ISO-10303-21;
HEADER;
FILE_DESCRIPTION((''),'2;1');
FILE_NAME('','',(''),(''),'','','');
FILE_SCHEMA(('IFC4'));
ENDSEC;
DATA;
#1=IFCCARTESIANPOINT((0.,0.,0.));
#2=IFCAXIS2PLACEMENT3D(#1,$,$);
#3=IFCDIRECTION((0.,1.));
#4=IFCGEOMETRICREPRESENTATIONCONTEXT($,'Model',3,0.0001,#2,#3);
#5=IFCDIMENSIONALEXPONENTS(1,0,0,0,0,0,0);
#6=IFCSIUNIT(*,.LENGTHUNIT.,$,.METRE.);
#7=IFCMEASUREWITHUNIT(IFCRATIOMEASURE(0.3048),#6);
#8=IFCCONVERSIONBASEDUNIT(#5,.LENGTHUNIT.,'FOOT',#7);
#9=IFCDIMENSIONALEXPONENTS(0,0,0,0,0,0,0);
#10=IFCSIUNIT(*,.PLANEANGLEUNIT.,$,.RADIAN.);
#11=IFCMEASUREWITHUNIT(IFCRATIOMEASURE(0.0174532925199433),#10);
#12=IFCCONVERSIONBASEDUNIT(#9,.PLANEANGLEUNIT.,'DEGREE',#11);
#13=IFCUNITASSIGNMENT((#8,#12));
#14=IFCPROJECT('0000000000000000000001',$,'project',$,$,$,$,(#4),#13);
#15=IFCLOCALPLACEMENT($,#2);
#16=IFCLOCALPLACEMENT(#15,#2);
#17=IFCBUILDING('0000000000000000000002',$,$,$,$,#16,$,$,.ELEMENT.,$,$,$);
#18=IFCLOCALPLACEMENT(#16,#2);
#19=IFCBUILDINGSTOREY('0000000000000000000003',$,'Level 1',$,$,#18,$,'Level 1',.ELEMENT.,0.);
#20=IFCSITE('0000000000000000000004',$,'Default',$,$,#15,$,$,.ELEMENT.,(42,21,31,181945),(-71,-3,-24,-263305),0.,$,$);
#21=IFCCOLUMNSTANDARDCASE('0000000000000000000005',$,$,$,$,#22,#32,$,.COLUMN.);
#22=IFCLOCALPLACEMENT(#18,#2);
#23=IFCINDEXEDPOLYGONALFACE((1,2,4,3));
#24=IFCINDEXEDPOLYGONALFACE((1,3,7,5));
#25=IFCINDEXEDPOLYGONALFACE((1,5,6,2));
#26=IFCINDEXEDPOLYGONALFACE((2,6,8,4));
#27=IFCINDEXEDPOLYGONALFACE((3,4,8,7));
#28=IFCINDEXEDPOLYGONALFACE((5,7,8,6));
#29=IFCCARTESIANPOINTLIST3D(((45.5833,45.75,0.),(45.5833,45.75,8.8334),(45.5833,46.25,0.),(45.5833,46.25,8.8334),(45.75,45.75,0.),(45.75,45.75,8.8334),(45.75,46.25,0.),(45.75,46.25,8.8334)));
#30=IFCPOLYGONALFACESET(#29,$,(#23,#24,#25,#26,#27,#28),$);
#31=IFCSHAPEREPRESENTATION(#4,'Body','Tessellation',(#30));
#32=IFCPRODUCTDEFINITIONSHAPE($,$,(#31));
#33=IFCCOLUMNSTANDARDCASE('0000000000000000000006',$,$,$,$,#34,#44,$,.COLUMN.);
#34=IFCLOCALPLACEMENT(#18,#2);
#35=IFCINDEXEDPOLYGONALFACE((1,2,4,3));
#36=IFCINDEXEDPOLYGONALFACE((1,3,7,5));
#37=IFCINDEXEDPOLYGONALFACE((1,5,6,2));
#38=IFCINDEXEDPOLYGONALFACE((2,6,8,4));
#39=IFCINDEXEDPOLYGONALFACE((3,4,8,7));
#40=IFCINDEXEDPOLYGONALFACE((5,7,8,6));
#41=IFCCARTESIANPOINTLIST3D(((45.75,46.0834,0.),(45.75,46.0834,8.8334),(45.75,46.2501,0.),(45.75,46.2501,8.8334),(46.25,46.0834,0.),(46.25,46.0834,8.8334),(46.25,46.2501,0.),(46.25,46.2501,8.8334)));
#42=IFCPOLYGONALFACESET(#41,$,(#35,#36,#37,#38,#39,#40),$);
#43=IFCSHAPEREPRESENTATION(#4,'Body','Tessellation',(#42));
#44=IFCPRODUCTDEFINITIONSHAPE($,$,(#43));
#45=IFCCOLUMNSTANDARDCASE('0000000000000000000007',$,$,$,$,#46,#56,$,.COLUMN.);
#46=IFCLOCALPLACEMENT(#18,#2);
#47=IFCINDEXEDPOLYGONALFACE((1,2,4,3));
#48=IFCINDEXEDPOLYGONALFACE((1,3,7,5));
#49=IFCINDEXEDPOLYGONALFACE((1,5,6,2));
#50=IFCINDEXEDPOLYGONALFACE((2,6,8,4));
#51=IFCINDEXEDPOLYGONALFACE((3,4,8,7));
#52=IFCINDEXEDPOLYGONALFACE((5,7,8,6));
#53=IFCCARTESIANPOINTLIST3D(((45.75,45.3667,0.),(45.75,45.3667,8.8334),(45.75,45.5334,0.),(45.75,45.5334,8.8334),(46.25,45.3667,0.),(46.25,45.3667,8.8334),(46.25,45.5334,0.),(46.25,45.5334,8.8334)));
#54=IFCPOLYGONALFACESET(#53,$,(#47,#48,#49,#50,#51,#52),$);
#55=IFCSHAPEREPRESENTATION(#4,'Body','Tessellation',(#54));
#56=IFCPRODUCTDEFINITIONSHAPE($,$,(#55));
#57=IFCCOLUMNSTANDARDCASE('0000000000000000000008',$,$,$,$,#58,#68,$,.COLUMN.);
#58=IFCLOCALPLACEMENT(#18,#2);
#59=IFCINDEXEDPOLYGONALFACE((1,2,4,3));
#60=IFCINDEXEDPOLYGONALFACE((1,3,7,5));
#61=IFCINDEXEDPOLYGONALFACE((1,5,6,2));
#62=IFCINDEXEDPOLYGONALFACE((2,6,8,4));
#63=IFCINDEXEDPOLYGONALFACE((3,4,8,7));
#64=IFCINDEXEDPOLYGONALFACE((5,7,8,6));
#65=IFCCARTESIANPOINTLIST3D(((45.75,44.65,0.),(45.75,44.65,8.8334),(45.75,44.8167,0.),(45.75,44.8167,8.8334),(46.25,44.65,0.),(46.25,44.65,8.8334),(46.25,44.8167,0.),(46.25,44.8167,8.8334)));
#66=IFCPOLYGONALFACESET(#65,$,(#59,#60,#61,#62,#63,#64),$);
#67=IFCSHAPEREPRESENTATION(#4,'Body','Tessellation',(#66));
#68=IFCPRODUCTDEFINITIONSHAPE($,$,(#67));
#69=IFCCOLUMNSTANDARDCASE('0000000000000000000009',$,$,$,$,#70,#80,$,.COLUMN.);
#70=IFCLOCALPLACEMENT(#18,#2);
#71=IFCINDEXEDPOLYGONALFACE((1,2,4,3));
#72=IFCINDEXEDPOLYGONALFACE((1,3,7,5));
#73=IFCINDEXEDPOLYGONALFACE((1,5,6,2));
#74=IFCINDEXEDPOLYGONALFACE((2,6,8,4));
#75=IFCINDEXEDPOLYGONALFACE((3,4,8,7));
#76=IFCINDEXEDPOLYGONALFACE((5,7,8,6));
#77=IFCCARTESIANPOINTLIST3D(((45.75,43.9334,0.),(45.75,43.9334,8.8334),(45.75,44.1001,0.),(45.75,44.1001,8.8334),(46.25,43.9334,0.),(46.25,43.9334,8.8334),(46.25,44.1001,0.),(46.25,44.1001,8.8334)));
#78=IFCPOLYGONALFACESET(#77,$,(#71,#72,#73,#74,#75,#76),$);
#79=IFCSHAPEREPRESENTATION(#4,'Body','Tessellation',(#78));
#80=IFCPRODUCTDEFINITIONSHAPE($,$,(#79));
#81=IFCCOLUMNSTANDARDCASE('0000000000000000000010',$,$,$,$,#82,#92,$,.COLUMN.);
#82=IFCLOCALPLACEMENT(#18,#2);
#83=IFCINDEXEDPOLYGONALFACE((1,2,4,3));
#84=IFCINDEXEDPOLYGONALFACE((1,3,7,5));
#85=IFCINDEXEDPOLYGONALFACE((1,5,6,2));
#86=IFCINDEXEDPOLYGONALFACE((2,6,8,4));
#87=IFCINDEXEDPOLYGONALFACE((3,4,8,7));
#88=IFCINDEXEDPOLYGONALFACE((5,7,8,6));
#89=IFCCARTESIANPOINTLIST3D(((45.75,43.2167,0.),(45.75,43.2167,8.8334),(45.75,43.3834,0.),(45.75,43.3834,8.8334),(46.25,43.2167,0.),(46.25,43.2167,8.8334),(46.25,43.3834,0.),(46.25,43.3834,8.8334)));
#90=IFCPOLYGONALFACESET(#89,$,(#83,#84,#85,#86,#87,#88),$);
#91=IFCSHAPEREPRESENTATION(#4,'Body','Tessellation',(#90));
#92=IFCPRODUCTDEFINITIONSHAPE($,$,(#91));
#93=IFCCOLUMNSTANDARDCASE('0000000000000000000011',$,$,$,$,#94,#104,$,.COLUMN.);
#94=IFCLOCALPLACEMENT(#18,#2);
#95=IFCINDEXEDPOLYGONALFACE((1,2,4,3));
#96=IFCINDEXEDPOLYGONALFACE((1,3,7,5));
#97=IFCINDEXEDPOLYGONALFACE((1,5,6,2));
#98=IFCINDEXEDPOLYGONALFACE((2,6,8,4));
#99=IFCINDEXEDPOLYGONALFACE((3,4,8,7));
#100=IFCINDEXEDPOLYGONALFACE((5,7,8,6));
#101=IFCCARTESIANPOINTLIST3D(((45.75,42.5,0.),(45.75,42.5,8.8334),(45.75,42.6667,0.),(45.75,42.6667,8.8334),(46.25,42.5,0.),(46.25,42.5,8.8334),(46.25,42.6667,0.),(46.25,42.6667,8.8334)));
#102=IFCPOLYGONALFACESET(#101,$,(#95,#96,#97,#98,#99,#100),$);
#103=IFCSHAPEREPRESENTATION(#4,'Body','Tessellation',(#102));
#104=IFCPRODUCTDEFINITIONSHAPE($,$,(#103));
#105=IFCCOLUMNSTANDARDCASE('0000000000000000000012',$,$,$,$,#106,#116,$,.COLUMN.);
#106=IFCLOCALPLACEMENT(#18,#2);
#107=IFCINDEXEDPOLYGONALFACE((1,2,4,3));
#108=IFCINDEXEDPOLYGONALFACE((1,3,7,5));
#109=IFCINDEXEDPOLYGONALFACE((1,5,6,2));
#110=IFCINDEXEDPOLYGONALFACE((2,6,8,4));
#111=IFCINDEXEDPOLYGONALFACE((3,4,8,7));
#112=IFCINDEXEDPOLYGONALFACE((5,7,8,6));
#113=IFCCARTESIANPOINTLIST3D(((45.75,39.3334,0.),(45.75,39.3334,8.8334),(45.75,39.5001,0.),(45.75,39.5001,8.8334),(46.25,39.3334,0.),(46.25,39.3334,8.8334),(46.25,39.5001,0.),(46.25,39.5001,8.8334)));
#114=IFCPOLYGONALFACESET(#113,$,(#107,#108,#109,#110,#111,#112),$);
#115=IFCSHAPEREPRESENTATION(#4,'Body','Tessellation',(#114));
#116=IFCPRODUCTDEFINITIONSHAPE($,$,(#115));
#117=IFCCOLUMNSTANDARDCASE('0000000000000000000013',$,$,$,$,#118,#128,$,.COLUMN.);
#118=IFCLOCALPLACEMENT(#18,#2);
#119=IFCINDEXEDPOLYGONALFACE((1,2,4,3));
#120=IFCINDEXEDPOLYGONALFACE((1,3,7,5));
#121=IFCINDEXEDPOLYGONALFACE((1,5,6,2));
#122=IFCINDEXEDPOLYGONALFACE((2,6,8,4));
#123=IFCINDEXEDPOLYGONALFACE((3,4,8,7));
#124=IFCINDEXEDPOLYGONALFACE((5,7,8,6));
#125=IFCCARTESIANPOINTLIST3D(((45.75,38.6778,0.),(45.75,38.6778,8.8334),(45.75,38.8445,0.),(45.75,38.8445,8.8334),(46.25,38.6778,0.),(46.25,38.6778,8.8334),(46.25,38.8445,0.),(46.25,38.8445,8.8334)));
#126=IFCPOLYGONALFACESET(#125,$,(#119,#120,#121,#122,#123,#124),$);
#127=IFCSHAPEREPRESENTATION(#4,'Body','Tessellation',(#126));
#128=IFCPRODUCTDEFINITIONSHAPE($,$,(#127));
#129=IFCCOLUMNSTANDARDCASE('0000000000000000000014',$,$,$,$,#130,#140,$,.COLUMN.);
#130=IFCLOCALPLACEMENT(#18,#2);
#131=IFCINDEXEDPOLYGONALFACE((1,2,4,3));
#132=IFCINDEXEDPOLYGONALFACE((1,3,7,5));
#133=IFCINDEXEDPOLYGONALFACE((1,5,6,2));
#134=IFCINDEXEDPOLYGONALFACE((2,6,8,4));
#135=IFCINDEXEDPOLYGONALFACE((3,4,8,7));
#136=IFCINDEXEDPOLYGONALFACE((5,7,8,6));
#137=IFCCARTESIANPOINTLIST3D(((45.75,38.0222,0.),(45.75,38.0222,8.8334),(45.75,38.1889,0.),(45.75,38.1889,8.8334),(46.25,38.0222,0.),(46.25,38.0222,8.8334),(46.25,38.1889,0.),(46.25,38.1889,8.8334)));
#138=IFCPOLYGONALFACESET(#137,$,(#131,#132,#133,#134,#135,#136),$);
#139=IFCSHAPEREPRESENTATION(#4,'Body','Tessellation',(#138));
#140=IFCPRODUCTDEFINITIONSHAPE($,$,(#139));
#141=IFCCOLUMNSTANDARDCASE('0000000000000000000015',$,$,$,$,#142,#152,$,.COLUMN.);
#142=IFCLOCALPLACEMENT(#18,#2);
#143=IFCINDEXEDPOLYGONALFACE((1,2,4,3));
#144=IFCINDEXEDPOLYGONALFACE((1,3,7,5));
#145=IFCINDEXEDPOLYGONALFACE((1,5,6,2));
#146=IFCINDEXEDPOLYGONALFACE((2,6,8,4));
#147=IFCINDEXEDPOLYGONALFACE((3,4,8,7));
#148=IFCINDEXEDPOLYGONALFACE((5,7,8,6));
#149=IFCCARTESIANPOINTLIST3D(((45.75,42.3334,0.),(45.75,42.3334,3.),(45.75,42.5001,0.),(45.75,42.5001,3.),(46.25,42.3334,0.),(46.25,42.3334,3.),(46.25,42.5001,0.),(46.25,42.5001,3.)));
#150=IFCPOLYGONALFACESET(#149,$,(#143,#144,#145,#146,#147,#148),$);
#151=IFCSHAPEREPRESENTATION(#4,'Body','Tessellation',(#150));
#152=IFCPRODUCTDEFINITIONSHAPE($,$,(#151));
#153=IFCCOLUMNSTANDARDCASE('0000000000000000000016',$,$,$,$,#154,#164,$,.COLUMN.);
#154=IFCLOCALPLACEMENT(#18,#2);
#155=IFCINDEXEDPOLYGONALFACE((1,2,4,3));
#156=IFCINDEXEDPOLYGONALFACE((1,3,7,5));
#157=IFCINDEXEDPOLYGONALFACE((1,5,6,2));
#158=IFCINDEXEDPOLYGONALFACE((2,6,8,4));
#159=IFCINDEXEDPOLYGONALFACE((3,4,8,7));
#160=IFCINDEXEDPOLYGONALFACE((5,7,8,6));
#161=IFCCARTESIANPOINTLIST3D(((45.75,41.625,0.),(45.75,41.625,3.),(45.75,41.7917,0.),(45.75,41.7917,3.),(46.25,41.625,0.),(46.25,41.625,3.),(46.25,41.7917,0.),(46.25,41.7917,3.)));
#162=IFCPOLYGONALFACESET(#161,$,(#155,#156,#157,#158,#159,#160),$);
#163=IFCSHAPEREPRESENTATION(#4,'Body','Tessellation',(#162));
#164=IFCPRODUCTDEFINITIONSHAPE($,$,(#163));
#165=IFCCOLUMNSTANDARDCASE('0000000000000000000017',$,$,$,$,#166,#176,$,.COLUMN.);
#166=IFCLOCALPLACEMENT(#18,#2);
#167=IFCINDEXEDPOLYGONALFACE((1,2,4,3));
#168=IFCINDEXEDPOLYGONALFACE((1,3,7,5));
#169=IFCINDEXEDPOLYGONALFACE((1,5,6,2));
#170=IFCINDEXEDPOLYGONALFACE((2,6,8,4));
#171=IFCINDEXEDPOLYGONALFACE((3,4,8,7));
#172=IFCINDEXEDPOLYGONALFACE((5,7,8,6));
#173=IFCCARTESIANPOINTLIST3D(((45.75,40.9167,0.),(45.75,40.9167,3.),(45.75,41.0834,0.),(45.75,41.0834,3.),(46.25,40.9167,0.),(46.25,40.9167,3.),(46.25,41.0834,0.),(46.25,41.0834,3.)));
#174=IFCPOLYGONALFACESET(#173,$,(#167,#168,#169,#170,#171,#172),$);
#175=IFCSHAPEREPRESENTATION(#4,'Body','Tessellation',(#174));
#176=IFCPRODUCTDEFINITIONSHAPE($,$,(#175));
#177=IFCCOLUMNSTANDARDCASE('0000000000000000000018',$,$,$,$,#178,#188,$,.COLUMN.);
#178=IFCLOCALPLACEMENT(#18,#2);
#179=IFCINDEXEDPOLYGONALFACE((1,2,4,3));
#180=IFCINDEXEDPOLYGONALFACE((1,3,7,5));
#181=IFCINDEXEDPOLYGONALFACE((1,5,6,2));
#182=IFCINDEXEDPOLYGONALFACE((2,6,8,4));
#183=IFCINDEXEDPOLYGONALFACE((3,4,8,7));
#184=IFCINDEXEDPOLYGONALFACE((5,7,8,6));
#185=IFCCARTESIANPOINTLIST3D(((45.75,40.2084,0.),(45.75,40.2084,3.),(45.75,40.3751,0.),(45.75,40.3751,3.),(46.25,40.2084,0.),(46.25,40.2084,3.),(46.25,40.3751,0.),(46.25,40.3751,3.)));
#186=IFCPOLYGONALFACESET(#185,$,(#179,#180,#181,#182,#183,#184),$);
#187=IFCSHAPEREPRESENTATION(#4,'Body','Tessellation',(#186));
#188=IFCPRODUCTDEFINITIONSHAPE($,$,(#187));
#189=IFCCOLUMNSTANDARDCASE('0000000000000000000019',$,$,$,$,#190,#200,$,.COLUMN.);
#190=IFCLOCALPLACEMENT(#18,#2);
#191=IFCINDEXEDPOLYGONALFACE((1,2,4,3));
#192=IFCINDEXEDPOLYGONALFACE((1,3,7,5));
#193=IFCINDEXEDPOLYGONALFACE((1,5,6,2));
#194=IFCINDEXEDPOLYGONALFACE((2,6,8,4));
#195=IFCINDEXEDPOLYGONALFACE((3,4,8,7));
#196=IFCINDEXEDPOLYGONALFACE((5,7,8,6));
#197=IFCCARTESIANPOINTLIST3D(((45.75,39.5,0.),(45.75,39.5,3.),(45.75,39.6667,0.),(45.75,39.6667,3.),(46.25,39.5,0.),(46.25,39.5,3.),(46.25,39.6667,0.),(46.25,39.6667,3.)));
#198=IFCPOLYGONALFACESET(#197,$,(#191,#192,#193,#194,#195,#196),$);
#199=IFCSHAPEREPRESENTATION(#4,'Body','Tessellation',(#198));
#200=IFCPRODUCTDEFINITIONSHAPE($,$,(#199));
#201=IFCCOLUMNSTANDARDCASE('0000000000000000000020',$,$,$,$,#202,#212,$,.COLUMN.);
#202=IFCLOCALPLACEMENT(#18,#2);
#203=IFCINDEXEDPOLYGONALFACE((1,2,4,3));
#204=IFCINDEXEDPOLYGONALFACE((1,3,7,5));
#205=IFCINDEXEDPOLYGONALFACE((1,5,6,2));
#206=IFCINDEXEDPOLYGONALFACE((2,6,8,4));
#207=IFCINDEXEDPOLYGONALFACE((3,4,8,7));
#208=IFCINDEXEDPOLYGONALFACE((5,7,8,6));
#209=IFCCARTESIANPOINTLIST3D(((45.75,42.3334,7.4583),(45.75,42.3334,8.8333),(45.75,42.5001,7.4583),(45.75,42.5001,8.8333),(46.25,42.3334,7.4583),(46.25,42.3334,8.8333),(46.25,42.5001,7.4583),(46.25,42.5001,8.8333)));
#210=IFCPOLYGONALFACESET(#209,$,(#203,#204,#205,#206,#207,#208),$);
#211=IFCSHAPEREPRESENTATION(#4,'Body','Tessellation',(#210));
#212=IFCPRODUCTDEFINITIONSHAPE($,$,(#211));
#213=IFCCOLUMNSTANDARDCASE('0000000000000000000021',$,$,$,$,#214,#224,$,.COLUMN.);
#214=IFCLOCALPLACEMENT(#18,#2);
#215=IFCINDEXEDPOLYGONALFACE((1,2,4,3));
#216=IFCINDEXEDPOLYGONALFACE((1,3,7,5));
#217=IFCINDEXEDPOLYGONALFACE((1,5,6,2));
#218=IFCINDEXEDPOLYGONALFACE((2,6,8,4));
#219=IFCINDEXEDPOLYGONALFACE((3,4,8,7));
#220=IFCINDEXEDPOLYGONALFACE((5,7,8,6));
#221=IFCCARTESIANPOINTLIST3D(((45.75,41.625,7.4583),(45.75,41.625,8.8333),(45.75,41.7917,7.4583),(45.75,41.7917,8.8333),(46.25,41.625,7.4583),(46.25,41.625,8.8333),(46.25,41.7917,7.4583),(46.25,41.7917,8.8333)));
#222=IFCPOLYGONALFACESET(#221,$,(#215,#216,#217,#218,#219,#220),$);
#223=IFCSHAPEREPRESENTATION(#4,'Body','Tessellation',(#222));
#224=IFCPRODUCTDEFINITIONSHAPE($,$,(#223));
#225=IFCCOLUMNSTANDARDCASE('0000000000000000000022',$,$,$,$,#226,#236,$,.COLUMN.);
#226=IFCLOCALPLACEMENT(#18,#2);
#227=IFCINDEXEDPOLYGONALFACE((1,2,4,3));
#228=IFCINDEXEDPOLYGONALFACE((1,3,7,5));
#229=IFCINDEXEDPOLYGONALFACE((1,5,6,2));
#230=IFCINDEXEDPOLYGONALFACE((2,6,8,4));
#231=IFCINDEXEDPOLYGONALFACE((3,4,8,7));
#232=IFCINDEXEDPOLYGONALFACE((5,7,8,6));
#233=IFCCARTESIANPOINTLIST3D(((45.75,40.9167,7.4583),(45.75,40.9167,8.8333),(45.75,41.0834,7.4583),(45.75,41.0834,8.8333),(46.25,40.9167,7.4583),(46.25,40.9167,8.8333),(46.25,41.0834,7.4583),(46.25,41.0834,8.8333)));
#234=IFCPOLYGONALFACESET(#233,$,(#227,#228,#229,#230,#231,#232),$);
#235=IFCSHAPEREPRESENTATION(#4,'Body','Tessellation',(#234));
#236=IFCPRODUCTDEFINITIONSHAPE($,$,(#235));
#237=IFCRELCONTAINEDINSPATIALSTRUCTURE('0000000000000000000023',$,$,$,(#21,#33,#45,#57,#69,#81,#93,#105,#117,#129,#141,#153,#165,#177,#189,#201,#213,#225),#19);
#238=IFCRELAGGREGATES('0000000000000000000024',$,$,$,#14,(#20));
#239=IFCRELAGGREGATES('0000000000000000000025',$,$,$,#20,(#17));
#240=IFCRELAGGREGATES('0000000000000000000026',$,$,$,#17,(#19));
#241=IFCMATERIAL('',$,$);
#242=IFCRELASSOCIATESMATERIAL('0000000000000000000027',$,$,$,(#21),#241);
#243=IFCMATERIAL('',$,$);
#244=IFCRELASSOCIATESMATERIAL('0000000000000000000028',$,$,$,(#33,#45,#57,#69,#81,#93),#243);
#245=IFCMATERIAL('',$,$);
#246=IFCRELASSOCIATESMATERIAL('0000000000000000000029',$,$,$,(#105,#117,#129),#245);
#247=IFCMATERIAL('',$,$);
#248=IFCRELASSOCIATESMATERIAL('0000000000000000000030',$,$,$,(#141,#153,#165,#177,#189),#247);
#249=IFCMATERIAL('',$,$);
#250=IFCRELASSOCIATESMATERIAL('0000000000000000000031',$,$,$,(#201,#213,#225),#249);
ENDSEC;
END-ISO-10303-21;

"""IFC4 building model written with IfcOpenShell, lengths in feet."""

from ifc_helpers import new_model, entity, si_unit, converted_unit, direction, frame, origin, place, context, project, spatial, rectangle, extrude, material, element, save


model = new_model("IFC4")

# Units and contexts
model_context = context("Model", 3, precision=0.0001, world=origin(), true_north=direction((0.0, 1.0)))
ifc_project = project(units=[converted_unit("LENGTHUNIT", "FOOT", entity("IfcRatioMeasure", 0.3048), si_unit("LENGTHUNIT", "METRE"), dimensions=[1, 0, 0, 0, 0, 0, 0]), converted_unit("PLANEANGLEUNIT", "DEGREE", entity("IfcRatioMeasure", 0.0174532925199433), si_unit("PLANEANGLEUNIT", "RADIAN"), dimensions=[0, 0, 0, 0, 0, 0, 0])], contexts=[model_context])

# Site, building, storey
site_placement = place(None, origin())
site = spatial("IfcSite", under=ifc_project, at=site_placement, Name="Default", CompositionType="ELEMENT", RefLatitude=(42, 21, 31, 181945), RefLongitude=(-71, -3, -24, -263305), RefElevation=0.0)
building_placement = place(site_placement, origin())
building = spatial("IfcBuilding", under=site, at=building_placement, CompositionType="ELEMENT")
storey_placement = place(building_placement, origin())
storey = spatial("IfcBuildingStorey", under=building, at=storey_placement, Name="Level 1", LongName="Level 1", CompositionType="ELEMENT", Elevation=0.0)

# Columns
ifc_material_1 = material(Name="")
placement_1 = place(storey_placement, frame((-0.25, 46.0, 0.0)))
column_placement = place(placement_1, frame((45.9167, 0.0, 0.0), z_axis=(0.0, 0.0, 1.0), x_axis=(1.0, 0.0, 0.0)))
element("IfcColumnStandardCase", 1, at=column_placement, inside=storey, material=ifc_material_1, PredefinedType="COLUMN", context=model_context, shape_type="SweptSolid", body=[
    extrude(rectangle(XDim=0.1667, YDim=0.5), origin(), (0.0, 0.0, 1.0), 8.8334),
])
ifc_material_2 = material(Name="")
placement_2 = place(storey_placement, frame((46.0, 46.25, 0.0), z_axis=(0.0, 0.0, 1.0), x_axis=(0.0, -1.0, 0.0)))
for number, where, z_axis, x_axis in (
    (2, (0.0833, 0.0, 0.0), (0.0, 0.0, 1.0), (1.0, 0.0, 0.0)),
    (3, (0.8, 0.0, 0.0), (0.0, 0.0, 1.0), (1.0, 0.0, 0.0)),
    (4, (1.5167, 0.0, 0.0), (0.0, 0.0, 1.0), (1.0, 0.0, 0.0)),
    (5, (2.2333, 0.0, 0.0), (0.0, 0.0, 1.0), (1.0, 0.0, 0.0)),
    (6, (2.95, 0.0, 0.0), (0.0, 0.0, 1.0), (1.0, 0.0, 0.0)),
    (7, (3.6667, 0.0, 0.0), (0.0, 0.0, 1.0), (1.0, 0.0, 0.0)),
):
    element("IfcColumnStandardCase", number, at=place(placement_2, frame(where, z_axis=z_axis, x_axis=x_axis)), inside=storey, material=ifc_material_2, PredefinedType="COLUMN", context=model_context, shape_type="SweptSolid", body=[
        extrude(rectangle(XDim=0.1667, YDim=0.5), origin(), (0.0, 0.0, 1.0), 8.8334),
    ])
ifc_material_3 = material(Name="")
for number, where, z_axis, x_axis in (
    (8, (6.8333, 0.0, 0.0), (0.0, 0.0, 1.0), (1.0, 0.0, 0.0)),
    (9, (7.4889, 0.0, 0.0), (0.0, 0.0, 1.0), (1.0, 0.0, 0.0)),
    (10, (8.1445, 0.0, 0.0), (0.0, 0.0, 1.0), (1.0, 0.0, 0.0)),
):
    element("IfcColumnStandardCase", number, at=place(placement_2, frame(where, z_axis=z_axis, x_axis=x_axis)), inside=storey, material=ifc_material_3, PredefinedType="COLUMN", context=model_context, shape_type="SweptSolid", body=[
        extrude(rectangle(XDim=0.1667, YDim=0.5), origin(), (0.0, 0.0, 1.0), 8.8334),
    ])
ifc_material_4 = material(Name="")
for number, where, z_axis, x_axis in (
    (11, (3.8333, 0.0, 0.0), (0.0, 0.0, 1.0), (1.0, 0.0, 0.0)),
    (12, (4.5417, 0.0, 0.0), (0.0, 0.0, 1.0), (1.0, 0.0, 0.0)),
    (13, (5.25, 0.0, 0.0), (0.0, 0.0, 1.0), (1.0, 0.0, 0.0)),
    (14, (5.9583, 0.0, 0.0), (0.0, 0.0, 1.0), (1.0, 0.0, 0.0)),
    (15, (6.6667, 0.0, 0.0), (0.0, 0.0, 1.0), (1.0, 0.0, 0.0)),
):
    element("IfcColumnStandardCase", number, at=place(placement_2, frame(where, z_axis=z_axis, x_axis=x_axis)), inside=storey, material=ifc_material_4, PredefinedType="COLUMN", context=model_context, shape_type="SweptSolid", body=[
        extrude(rectangle(XDim=0.1667, YDim=0.5), origin(), (0.0, 0.0, 1.0), 3.0),
    ])
ifc_material_5 = material(Name="")
for number, where, z_axis, x_axis in (
    (16, (3.8333, 0.0, 7.4583), (0.0, 0.0, 1.0), (1.0, 0.0, 0.0)),
    (17, (4.5417, 0.0, 7.4583), (0.0, 0.0, 1.0), (1.0, 0.0, 0.0)),
    (18, (5.25, 0.0, 7.4583), (0.0, 0.0, 1.0), (1.0, 0.0, 0.0)),
):
    element("IfcColumnStandardCase", number, at=place(placement_2, frame(where, z_axis=z_axis, x_axis=x_axis)), inside=storey, material=ifc_material_5, PredefinedType="COLUMN", context=model_context, shape_type="SweptSolid", body=[
        extrude(rectangle(XDim=0.1667, YDim=0.5), origin(), (0.0, 0.0, 1.0), 1.375),
    ])

save(model, "model.ifc")
